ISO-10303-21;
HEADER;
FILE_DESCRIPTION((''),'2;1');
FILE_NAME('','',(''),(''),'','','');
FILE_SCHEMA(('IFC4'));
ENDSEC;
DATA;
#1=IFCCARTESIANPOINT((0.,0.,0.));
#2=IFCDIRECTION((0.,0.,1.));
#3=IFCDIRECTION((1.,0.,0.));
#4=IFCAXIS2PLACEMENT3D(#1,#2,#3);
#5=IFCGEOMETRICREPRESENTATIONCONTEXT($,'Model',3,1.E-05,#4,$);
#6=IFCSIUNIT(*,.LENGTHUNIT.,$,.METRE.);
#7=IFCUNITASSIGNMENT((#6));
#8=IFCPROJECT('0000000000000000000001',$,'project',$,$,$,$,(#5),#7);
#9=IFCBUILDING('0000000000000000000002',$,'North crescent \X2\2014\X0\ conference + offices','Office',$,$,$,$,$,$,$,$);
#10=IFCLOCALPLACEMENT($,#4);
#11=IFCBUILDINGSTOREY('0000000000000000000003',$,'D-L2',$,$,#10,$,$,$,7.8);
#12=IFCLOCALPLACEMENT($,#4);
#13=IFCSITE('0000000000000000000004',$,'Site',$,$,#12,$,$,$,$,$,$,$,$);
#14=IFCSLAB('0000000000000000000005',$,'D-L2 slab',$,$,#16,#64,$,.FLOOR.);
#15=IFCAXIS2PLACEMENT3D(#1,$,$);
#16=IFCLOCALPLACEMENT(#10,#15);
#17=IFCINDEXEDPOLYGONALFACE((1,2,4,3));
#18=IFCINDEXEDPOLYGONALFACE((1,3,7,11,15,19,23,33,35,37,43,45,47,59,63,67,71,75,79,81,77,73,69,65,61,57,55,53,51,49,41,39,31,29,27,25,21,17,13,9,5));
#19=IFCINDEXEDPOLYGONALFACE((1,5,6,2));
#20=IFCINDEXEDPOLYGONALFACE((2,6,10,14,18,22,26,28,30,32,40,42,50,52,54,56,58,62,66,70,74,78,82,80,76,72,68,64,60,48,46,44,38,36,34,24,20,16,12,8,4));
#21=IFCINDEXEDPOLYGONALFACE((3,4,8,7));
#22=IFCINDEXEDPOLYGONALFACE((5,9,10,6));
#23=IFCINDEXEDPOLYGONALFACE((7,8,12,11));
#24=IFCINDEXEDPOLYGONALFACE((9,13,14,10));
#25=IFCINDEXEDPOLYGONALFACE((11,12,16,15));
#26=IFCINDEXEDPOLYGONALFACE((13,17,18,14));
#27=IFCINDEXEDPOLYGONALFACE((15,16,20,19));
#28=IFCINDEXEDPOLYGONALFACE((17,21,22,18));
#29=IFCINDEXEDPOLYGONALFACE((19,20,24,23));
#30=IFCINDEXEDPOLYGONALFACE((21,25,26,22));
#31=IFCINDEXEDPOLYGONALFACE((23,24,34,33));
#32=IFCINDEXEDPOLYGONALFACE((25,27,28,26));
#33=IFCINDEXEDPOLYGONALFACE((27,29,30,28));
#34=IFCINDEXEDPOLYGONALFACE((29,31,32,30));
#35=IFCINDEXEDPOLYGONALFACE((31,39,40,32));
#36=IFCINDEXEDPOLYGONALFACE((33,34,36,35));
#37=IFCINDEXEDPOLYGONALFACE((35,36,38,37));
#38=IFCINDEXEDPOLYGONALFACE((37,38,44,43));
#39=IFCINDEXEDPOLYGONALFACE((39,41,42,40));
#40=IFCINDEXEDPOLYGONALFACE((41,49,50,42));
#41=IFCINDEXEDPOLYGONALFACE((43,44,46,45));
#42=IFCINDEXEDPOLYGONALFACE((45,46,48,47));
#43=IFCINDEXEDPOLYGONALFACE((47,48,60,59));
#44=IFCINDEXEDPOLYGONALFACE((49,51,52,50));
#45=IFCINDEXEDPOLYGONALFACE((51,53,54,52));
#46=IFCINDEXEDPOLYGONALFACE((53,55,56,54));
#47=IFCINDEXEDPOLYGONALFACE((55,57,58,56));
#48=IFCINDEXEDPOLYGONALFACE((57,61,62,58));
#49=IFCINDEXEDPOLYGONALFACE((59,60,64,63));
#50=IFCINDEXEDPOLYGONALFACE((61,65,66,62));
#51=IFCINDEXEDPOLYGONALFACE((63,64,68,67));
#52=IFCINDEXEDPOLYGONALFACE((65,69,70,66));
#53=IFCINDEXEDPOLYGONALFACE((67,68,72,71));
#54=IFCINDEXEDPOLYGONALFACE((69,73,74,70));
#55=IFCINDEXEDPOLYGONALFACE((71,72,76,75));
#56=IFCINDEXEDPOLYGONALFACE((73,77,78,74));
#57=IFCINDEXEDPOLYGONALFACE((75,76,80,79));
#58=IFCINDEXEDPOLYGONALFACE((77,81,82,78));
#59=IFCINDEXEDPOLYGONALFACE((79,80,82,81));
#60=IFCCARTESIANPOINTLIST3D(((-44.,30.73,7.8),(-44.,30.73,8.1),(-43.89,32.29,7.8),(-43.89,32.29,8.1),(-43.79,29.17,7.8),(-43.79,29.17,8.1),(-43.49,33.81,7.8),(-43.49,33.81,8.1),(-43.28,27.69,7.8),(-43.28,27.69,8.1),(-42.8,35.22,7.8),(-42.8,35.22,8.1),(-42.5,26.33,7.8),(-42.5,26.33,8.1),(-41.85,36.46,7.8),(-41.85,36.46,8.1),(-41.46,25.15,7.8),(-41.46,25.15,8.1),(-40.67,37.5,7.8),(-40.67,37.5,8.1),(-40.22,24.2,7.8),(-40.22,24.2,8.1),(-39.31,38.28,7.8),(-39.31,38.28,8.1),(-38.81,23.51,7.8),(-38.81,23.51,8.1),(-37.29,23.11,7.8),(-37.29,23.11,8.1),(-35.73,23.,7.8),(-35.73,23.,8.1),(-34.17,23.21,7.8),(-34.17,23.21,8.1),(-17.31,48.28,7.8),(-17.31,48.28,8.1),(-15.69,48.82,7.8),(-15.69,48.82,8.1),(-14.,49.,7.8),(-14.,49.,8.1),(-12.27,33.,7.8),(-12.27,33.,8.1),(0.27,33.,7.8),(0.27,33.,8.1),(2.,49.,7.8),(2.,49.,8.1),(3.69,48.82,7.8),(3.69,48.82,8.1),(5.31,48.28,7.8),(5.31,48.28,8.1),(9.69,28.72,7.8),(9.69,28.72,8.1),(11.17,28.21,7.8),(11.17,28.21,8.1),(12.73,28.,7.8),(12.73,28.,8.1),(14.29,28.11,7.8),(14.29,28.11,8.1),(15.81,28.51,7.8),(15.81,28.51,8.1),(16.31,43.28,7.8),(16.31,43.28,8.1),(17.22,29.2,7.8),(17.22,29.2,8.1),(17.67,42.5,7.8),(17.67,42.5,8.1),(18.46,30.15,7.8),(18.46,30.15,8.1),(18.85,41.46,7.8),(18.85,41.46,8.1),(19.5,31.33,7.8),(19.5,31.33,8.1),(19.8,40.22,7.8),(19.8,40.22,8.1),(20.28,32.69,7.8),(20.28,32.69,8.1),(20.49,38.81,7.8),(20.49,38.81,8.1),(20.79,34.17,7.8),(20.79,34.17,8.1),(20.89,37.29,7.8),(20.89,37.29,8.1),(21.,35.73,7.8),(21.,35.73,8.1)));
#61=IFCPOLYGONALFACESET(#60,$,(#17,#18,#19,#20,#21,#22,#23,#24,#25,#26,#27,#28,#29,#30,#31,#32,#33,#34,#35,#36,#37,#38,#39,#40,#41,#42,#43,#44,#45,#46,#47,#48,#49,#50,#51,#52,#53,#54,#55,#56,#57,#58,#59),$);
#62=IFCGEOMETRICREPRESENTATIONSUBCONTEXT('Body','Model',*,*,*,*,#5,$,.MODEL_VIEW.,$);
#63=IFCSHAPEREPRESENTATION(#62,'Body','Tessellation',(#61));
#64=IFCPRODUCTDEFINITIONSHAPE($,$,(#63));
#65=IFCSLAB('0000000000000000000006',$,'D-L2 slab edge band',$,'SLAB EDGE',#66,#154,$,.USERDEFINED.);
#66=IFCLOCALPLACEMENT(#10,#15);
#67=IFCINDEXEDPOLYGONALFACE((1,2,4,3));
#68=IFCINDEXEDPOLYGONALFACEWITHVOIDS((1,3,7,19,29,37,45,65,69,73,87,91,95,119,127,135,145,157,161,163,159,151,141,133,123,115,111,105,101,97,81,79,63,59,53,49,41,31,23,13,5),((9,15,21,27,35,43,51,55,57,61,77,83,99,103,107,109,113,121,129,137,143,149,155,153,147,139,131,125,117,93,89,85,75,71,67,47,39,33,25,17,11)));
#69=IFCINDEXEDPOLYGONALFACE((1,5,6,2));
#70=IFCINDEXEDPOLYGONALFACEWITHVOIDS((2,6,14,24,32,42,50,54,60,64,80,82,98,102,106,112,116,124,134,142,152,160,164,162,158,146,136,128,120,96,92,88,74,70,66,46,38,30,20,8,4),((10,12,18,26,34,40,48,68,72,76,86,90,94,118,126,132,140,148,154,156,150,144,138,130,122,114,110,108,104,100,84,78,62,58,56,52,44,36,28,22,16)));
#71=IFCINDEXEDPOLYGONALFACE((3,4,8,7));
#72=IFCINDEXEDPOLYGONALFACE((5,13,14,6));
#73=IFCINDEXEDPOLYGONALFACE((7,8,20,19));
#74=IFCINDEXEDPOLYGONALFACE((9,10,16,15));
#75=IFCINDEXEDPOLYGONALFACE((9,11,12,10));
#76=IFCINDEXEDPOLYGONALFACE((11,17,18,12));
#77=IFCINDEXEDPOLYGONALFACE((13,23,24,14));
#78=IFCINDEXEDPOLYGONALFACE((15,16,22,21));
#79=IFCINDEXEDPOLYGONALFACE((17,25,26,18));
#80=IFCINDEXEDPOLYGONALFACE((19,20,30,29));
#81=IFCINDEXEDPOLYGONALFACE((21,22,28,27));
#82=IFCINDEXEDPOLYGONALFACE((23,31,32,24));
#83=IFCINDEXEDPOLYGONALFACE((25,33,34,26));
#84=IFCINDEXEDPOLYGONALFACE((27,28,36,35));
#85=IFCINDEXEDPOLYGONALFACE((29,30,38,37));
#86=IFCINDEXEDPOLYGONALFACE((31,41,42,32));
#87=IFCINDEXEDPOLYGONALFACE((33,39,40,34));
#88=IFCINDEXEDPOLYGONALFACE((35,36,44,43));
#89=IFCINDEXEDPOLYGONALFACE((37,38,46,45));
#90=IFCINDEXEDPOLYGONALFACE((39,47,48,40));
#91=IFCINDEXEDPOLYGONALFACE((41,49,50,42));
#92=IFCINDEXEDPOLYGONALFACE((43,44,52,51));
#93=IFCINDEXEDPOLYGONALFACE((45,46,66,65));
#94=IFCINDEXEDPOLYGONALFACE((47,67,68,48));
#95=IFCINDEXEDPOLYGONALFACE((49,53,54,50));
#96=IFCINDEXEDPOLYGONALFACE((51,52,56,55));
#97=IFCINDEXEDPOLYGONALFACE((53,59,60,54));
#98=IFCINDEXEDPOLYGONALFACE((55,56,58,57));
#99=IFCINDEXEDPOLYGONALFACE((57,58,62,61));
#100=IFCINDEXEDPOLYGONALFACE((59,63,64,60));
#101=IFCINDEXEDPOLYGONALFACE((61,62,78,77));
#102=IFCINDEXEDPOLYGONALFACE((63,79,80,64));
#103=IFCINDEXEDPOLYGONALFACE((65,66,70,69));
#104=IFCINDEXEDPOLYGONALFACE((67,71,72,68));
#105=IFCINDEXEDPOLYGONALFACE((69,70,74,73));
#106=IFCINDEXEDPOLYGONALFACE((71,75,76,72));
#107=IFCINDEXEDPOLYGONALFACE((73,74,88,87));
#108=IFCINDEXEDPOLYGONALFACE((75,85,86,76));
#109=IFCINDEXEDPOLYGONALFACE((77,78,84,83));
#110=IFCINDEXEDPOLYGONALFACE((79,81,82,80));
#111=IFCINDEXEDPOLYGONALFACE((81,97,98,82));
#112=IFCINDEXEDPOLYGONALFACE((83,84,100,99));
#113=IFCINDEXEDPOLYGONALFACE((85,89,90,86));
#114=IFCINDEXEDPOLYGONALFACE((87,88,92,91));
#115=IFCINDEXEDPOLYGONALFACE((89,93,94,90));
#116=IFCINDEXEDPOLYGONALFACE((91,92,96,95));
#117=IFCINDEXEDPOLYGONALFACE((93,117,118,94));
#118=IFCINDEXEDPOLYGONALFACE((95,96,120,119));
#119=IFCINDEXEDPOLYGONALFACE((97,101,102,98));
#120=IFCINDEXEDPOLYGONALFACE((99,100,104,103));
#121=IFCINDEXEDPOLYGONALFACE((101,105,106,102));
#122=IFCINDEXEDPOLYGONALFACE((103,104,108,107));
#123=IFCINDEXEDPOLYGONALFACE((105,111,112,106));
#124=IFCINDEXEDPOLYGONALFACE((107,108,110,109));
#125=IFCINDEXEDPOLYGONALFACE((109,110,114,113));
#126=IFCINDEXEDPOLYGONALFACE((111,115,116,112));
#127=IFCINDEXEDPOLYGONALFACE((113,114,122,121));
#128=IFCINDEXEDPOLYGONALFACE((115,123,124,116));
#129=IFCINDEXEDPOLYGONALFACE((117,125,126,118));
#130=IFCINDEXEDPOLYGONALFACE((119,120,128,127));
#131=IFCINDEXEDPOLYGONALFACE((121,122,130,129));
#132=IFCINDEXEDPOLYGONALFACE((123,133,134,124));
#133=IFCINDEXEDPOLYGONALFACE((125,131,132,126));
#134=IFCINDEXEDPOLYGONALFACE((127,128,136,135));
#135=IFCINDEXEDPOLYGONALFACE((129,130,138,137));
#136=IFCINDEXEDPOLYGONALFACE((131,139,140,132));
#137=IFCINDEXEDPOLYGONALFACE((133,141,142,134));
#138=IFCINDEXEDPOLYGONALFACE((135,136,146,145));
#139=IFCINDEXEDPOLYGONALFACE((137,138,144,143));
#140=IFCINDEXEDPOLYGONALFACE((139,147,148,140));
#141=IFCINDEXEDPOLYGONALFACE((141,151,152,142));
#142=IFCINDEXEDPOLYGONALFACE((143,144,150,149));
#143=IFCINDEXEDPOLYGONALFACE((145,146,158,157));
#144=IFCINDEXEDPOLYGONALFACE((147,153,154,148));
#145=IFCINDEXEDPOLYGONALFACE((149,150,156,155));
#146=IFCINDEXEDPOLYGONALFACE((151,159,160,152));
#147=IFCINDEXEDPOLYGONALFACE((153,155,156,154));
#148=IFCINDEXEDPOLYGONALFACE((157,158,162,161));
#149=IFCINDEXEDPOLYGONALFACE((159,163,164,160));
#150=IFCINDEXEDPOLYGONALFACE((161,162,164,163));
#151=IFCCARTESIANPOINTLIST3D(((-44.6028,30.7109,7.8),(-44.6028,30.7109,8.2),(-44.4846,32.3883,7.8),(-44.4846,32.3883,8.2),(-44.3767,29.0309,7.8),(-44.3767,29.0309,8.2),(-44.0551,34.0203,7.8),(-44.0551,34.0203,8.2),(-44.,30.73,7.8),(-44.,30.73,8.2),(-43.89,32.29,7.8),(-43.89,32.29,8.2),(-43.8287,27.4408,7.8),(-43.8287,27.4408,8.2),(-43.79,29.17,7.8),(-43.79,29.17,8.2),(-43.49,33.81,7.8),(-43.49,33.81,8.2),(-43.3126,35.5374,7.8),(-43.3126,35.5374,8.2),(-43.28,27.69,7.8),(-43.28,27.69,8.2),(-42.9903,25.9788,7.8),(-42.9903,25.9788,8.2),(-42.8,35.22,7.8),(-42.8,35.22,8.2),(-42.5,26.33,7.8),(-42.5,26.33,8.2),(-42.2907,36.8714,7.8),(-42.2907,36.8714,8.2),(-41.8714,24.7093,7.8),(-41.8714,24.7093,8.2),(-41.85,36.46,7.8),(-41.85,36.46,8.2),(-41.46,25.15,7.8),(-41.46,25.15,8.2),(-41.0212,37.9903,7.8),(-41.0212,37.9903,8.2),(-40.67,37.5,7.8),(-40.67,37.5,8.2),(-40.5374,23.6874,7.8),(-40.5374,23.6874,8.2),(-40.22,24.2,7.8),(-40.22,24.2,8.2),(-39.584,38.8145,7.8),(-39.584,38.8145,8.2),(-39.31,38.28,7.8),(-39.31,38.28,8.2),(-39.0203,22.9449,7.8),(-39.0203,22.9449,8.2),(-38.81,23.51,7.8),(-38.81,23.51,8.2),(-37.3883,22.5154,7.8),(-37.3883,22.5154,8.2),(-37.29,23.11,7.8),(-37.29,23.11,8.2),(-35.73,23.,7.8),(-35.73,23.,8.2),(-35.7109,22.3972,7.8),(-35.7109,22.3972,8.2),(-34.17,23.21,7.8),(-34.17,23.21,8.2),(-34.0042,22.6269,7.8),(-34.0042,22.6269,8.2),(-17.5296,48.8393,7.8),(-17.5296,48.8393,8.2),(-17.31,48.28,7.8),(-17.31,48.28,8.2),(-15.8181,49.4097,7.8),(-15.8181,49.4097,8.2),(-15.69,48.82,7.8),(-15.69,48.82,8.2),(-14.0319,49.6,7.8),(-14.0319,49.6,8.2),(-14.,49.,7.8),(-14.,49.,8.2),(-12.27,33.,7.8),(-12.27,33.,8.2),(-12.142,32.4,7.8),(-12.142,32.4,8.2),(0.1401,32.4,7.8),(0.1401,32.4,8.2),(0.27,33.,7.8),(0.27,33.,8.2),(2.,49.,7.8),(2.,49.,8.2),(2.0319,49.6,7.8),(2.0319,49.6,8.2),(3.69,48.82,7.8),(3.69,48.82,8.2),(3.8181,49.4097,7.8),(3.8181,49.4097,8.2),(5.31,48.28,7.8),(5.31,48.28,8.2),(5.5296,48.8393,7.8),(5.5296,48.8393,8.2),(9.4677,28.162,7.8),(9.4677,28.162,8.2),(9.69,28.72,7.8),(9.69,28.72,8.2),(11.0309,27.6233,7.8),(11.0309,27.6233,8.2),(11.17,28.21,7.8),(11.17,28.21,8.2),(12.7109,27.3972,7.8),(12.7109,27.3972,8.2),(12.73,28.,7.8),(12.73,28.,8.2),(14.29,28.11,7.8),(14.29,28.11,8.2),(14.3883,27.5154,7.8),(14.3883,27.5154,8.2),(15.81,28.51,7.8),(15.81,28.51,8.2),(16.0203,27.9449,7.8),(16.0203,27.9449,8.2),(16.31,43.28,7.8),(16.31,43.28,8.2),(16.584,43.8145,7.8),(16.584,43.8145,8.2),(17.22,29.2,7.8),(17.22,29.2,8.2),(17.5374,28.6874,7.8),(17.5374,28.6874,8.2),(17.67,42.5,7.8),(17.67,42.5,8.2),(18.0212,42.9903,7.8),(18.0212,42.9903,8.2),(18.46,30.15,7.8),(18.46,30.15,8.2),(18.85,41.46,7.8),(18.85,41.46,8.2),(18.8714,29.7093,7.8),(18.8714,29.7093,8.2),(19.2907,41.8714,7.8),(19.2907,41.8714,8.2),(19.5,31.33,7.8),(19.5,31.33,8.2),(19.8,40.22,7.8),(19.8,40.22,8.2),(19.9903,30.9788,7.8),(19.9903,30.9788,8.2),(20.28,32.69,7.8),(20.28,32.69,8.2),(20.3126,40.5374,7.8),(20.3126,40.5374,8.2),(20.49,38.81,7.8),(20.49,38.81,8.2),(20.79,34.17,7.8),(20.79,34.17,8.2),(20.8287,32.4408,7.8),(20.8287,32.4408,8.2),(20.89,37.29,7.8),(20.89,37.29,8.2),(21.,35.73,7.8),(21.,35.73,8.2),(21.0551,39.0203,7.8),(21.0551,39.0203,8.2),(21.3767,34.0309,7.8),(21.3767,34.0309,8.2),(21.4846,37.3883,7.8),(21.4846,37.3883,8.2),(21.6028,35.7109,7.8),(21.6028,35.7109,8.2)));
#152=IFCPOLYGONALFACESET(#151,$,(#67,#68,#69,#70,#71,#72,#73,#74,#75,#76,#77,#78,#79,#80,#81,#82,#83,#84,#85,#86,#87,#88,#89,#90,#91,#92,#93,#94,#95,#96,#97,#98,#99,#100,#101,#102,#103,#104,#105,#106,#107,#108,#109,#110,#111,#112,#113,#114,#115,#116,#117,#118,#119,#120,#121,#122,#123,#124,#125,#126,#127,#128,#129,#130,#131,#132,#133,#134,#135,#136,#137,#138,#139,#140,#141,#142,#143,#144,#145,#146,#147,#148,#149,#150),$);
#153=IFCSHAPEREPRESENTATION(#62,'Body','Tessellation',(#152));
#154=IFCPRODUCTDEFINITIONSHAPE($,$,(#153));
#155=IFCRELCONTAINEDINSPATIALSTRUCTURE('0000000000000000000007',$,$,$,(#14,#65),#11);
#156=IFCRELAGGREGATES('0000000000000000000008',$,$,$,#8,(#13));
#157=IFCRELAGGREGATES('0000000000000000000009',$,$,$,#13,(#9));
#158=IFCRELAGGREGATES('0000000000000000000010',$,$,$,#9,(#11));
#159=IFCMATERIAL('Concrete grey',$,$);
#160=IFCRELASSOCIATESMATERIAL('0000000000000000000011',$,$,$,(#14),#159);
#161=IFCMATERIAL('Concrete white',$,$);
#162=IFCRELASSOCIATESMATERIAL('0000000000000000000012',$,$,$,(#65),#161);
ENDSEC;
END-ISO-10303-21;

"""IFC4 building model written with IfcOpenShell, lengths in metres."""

from ifc_helpers import new_model, si_unit, frame, origin_with_axes, place, context, subcontext, project, spatial, polyline, outline, extrude, material, element, save


model = new_model("IFC4")

# Units and contexts
model_context = context("Model", 3, precision=1e-05, world=origin_with_axes())
body_context = subcontext(model_context, "Body", "Model", "MODEL_VIEW")
ifc_project = project(units=[si_unit("LENGTHUNIT", "METRE")], contexts=[model_context])

# Site, building, storey
site_placement = place(None, origin_with_axes())
site = spatial("IfcSite", under=ifc_project, at=site_placement, Name="Site")
building = spatial("IfcBuilding", under=site, Name="North crescent — conference + offices", Description="Office")
storey_placement = place(None, origin_with_axes())
storey = spatial("IfcBuildingStorey", under=building, at=storey_placement, Name="D-L2", Elevation=7.8)

# Slab
ifc_material_1 = material(Name="Concrete grey")
slab_1_placement = place(storey_placement, origin_with_axes())
element("IfcSlab", 1, at=slab_1_placement, inside=storey, material=ifc_material_1, Name="D-L2 slab", PredefinedType="FLOOR", context=body_context, shape_type="SweptSolid", body=[
    extrude(outline(polyline([(-17.31, 48.28), (-39.31, 38.28), (-40.67, 37.5), (-41.85, 36.46), (-42.8, 35.22), (-43.49, 33.81), (-43.89, 32.29), (-44.0, 30.73), (-43.79, 29.17), (-43.28, 27.69), (-42.5, 26.33), (-41.46, 25.15), (-40.22, 24.2), (-38.81, 23.51), (-37.29, 23.11), (-35.73, 23.0), (-34.17, 23.21), (-12.27, 33.0), (0.27, 33.0), (9.69, 28.72), (11.17, 28.21), (12.73, 28.0), (14.29, 28.11), (15.81, 28.51), (17.22, 29.2), (18.46, 30.15), (19.5, 31.33), (20.28, 32.69), (20.79, 34.17), (21.0, 35.73), (20.89, 37.29), (20.49, 38.81), (19.8, 40.22), (18.85, 41.46), (17.67, 42.5), (16.31, 43.28), (5.31, 48.28), (3.69, 48.82), (2.0, 49.0), (-14.0, 49.0), (-15.69, 48.82), (-17.31, 48.28)])), frame((0.0, 0.0, 7.8), z_axis=(0.0, 0.0, 1.0), x_axis=(1.0, 0.0, 0.0)), (0.0, 0.0, 1.0), 0.3),
])

# Slab
ifc_material_2 = material(Name="Concrete white")
slab_2_placement = place(storey_placement, origin_with_axes())
element("IfcSlab", 2, at=slab_2_placement, inside=storey, material=ifc_material_2, Name="D-L2 slab edge band", ObjectType="SLAB EDGE", PredefinedType="USERDEFINED", context=body_context, shape_type="SweptSolid", body=[
    extrude(outline(polyline([(-17.5296, 48.8393), (-39.584, 38.8145), (-41.0212, 37.9903), (-42.2907, 36.8714), (-43.3126, 35.5374), (-44.0551, 34.0203), (-44.4846, 32.3883), (-44.6028, 30.7109), (-44.3767, 29.0309), (-43.8287, 27.4408), (-42.9903, 25.9788), (-41.8714, 24.7093), (-40.5374, 23.6874), (-39.0203, 22.9449), (-37.3883, 22.5154), (-35.7109, 22.3972), (-34.0042, 22.6269), (-12.142, 32.4), (0.1401, 32.4), (9.4677, 28.162), (11.0309, 27.6233), (12.7109, 27.3972), (14.3883, 27.5154), (16.0203, 27.9449), (17.5374, 28.6874), (18.8714, 29.7093), (19.9903, 30.9788), (20.8287, 32.4408), (21.3767, 34.0309), (21.6028, 35.7109), (21.4846, 37.3883), (21.0551, 39.0203), (20.3126, 40.5374), (19.2907, 41.8714), (18.0212, 42.9903), (16.584, 43.8145), (5.5296, 48.8393), (3.8181, 49.4097), (2.0319, 49.6), (-14.0319, 49.6), (-15.8181, 49.4097), (-17.5296, 48.8393)]), holes=[polyline([(-17.31, 48.28), (-39.31, 38.28), (-40.67, 37.5), (-41.85, 36.46), (-42.8, 35.22), (-43.49, 33.81), (-43.89, 32.29), (-44.0, 30.73), (-43.79, 29.17), (-43.28, 27.69), (-42.5, 26.33), (-41.46, 25.15), (-40.22, 24.2), (-38.81, 23.51), (-37.29, 23.11), (-35.73, 23.0), (-34.17, 23.21), (-12.27, 33.0), (0.27, 33.0), (9.69, 28.72), (11.17, 28.21), (12.73, 28.0), (14.29, 28.11), (15.81, 28.51), (17.22, 29.2), (18.46, 30.15), (19.5, 31.33), (20.28, 32.69), (20.79, 34.17), (21.0, 35.73), (20.89, 37.29), (20.49, 38.81), (19.8, 40.22), (18.85, 41.46), (17.67, 42.5), (16.31, 43.28), (5.31, 48.28), (3.69, 48.82), (2.0, 49.0), (-14.0, 49.0), (-15.69, 48.82), (-17.31, 48.28)])]), frame((0.0, 0.0, 7.8), z_axis=(0.0, 0.0, 1.0), x_axis=(1.0, 0.0, 0.0)), (0.0, 0.0, 1.0), 0.4),
])

save(model, "model.ifc")
